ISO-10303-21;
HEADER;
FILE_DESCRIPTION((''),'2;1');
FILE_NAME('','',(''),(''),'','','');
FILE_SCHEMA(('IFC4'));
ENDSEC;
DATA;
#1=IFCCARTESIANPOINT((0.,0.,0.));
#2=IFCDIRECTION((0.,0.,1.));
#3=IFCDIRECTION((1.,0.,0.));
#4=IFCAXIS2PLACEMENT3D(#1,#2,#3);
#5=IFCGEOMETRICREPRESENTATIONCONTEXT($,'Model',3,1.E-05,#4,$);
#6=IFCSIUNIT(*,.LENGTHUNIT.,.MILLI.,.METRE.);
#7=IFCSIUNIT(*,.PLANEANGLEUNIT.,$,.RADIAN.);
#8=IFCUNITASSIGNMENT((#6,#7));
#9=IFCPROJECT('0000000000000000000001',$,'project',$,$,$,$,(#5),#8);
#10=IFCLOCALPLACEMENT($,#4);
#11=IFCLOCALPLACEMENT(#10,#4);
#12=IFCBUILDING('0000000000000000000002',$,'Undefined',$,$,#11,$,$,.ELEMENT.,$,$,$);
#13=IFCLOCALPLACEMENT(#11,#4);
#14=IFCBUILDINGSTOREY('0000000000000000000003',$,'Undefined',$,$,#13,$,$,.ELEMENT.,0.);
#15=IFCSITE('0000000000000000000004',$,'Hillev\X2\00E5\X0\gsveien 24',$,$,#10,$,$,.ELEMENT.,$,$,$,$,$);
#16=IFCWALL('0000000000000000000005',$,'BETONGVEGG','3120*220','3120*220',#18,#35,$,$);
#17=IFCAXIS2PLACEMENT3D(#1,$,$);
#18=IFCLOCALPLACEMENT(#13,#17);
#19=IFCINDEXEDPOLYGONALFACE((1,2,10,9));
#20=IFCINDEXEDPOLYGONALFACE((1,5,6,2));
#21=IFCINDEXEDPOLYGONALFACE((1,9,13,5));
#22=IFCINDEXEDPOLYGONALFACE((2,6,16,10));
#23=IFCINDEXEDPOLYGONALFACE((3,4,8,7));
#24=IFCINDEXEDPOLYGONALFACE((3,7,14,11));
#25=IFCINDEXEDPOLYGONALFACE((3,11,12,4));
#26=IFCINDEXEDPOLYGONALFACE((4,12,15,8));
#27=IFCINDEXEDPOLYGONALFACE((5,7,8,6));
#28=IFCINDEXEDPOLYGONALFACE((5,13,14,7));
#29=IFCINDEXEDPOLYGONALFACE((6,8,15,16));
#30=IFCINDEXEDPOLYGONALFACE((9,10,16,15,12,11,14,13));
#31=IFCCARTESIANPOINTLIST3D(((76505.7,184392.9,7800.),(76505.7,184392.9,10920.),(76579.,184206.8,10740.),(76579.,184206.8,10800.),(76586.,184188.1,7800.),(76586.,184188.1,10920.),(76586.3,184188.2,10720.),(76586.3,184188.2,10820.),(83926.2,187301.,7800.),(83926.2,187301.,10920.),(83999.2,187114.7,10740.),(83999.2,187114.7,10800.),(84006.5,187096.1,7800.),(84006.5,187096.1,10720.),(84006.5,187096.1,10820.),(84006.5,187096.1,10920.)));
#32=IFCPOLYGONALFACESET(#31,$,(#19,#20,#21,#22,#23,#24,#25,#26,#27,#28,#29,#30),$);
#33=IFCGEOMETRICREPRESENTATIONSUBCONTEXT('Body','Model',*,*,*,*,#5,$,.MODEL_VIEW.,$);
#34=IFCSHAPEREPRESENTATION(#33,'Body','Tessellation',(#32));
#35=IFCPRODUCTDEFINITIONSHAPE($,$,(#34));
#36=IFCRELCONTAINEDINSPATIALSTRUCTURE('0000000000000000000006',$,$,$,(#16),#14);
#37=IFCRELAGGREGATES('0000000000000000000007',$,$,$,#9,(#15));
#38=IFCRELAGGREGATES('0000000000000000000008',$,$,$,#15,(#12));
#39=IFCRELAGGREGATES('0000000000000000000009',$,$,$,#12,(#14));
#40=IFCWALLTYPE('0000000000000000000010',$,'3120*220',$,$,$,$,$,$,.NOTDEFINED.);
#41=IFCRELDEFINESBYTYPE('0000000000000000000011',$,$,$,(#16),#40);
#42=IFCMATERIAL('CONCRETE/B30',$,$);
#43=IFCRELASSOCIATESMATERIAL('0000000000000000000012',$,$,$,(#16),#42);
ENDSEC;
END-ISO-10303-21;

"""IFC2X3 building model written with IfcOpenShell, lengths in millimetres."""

from ifc_helpers import new_model, si_unit, frame, frame_2d, origin_with_axes, place, context, subcontext, project, spatial, polyline, rectangle, outline, extrude, boolean, material, type_object, element, save


model = new_model("IFC2X3")

# Units and contexts
model_context = context("Model", 3, precision=1e-05, world=origin_with_axes())
body_context = subcontext(model_context, "Body", "Model", "MODEL_VIEW")
ifc_project = project(units=[si_unit("LENGTHUNIT", "METRE", prefix="MILLI"), si_unit("PLANEANGLEUNIT", "RADIAN")], contexts=[model_context])

# Site, building, storey
site_placement = place(None, origin_with_axes())
site = spatial("IfcSite", under=ifc_project, at=site_placement, Name="Hillevågsveien 24", CompositionType="ELEMENT")
building_placement = place(site_placement, origin_with_axes())
building = spatial("IfcBuilding", under=site, at=building_placement, Name="Undefined", CompositionType="ELEMENT")
storey_placement = place(building_placement, origin_with_axes())
storey = spatial("IfcBuildingStorey", under=building, at=storey_placement, Name="Undefined", CompositionType="ELEMENT", Elevation=0.0)

# Shared definitions
ifc_material_1 = material(Name="CONCRETE/B30")

# Wall
wall_type = type_object("IfcWallType", Name="3120*220", PredefinedType="NOTDEFINED")
wall_placement = place(storey_placement, frame((83966.3, 187198.5, 7800.0), z_axis=(0.0, 0.0, 1.0), x_axis=(-0.931057, -0.364874, 0.0)))
element("IfcWall", 1, at=wall_placement, inside=storey, type_object=wall_type, material=ifc_material_1, Name="BETONGVEGG", Description="3120*220", ObjectType="3120*220", context=body_context, shape_type="CSG", body=[
    boolean("DIFFERENCE", extrude(rectangle(XDim=7970.0, YDim=220.0, at=frame_2d((0.0, 3985.0), x_axis=(0.0, -1.0))), frame((0.0, 0.0, 0.0), z_axis=(0.0, 0.0, 1.0), x_axis=(0.0, -1.0, 0.0)), (0.0, 0.0, 1.0), 3120.0), extrude(outline(polyline([(30.0, 10.0), (50.0, -10.0), (-50.0, -10.0), (-30.0, 10.0), (30.0, 10.0)])), frame((0.0, 100.0, 2970.0), z_axis=(1.0, 0.000003, 0.0), x_axis=(0.0, 0.0, 1.0)), (0.0, 0.0, 1.0), 7969.7)),
])

save(model, "model.ifc")
